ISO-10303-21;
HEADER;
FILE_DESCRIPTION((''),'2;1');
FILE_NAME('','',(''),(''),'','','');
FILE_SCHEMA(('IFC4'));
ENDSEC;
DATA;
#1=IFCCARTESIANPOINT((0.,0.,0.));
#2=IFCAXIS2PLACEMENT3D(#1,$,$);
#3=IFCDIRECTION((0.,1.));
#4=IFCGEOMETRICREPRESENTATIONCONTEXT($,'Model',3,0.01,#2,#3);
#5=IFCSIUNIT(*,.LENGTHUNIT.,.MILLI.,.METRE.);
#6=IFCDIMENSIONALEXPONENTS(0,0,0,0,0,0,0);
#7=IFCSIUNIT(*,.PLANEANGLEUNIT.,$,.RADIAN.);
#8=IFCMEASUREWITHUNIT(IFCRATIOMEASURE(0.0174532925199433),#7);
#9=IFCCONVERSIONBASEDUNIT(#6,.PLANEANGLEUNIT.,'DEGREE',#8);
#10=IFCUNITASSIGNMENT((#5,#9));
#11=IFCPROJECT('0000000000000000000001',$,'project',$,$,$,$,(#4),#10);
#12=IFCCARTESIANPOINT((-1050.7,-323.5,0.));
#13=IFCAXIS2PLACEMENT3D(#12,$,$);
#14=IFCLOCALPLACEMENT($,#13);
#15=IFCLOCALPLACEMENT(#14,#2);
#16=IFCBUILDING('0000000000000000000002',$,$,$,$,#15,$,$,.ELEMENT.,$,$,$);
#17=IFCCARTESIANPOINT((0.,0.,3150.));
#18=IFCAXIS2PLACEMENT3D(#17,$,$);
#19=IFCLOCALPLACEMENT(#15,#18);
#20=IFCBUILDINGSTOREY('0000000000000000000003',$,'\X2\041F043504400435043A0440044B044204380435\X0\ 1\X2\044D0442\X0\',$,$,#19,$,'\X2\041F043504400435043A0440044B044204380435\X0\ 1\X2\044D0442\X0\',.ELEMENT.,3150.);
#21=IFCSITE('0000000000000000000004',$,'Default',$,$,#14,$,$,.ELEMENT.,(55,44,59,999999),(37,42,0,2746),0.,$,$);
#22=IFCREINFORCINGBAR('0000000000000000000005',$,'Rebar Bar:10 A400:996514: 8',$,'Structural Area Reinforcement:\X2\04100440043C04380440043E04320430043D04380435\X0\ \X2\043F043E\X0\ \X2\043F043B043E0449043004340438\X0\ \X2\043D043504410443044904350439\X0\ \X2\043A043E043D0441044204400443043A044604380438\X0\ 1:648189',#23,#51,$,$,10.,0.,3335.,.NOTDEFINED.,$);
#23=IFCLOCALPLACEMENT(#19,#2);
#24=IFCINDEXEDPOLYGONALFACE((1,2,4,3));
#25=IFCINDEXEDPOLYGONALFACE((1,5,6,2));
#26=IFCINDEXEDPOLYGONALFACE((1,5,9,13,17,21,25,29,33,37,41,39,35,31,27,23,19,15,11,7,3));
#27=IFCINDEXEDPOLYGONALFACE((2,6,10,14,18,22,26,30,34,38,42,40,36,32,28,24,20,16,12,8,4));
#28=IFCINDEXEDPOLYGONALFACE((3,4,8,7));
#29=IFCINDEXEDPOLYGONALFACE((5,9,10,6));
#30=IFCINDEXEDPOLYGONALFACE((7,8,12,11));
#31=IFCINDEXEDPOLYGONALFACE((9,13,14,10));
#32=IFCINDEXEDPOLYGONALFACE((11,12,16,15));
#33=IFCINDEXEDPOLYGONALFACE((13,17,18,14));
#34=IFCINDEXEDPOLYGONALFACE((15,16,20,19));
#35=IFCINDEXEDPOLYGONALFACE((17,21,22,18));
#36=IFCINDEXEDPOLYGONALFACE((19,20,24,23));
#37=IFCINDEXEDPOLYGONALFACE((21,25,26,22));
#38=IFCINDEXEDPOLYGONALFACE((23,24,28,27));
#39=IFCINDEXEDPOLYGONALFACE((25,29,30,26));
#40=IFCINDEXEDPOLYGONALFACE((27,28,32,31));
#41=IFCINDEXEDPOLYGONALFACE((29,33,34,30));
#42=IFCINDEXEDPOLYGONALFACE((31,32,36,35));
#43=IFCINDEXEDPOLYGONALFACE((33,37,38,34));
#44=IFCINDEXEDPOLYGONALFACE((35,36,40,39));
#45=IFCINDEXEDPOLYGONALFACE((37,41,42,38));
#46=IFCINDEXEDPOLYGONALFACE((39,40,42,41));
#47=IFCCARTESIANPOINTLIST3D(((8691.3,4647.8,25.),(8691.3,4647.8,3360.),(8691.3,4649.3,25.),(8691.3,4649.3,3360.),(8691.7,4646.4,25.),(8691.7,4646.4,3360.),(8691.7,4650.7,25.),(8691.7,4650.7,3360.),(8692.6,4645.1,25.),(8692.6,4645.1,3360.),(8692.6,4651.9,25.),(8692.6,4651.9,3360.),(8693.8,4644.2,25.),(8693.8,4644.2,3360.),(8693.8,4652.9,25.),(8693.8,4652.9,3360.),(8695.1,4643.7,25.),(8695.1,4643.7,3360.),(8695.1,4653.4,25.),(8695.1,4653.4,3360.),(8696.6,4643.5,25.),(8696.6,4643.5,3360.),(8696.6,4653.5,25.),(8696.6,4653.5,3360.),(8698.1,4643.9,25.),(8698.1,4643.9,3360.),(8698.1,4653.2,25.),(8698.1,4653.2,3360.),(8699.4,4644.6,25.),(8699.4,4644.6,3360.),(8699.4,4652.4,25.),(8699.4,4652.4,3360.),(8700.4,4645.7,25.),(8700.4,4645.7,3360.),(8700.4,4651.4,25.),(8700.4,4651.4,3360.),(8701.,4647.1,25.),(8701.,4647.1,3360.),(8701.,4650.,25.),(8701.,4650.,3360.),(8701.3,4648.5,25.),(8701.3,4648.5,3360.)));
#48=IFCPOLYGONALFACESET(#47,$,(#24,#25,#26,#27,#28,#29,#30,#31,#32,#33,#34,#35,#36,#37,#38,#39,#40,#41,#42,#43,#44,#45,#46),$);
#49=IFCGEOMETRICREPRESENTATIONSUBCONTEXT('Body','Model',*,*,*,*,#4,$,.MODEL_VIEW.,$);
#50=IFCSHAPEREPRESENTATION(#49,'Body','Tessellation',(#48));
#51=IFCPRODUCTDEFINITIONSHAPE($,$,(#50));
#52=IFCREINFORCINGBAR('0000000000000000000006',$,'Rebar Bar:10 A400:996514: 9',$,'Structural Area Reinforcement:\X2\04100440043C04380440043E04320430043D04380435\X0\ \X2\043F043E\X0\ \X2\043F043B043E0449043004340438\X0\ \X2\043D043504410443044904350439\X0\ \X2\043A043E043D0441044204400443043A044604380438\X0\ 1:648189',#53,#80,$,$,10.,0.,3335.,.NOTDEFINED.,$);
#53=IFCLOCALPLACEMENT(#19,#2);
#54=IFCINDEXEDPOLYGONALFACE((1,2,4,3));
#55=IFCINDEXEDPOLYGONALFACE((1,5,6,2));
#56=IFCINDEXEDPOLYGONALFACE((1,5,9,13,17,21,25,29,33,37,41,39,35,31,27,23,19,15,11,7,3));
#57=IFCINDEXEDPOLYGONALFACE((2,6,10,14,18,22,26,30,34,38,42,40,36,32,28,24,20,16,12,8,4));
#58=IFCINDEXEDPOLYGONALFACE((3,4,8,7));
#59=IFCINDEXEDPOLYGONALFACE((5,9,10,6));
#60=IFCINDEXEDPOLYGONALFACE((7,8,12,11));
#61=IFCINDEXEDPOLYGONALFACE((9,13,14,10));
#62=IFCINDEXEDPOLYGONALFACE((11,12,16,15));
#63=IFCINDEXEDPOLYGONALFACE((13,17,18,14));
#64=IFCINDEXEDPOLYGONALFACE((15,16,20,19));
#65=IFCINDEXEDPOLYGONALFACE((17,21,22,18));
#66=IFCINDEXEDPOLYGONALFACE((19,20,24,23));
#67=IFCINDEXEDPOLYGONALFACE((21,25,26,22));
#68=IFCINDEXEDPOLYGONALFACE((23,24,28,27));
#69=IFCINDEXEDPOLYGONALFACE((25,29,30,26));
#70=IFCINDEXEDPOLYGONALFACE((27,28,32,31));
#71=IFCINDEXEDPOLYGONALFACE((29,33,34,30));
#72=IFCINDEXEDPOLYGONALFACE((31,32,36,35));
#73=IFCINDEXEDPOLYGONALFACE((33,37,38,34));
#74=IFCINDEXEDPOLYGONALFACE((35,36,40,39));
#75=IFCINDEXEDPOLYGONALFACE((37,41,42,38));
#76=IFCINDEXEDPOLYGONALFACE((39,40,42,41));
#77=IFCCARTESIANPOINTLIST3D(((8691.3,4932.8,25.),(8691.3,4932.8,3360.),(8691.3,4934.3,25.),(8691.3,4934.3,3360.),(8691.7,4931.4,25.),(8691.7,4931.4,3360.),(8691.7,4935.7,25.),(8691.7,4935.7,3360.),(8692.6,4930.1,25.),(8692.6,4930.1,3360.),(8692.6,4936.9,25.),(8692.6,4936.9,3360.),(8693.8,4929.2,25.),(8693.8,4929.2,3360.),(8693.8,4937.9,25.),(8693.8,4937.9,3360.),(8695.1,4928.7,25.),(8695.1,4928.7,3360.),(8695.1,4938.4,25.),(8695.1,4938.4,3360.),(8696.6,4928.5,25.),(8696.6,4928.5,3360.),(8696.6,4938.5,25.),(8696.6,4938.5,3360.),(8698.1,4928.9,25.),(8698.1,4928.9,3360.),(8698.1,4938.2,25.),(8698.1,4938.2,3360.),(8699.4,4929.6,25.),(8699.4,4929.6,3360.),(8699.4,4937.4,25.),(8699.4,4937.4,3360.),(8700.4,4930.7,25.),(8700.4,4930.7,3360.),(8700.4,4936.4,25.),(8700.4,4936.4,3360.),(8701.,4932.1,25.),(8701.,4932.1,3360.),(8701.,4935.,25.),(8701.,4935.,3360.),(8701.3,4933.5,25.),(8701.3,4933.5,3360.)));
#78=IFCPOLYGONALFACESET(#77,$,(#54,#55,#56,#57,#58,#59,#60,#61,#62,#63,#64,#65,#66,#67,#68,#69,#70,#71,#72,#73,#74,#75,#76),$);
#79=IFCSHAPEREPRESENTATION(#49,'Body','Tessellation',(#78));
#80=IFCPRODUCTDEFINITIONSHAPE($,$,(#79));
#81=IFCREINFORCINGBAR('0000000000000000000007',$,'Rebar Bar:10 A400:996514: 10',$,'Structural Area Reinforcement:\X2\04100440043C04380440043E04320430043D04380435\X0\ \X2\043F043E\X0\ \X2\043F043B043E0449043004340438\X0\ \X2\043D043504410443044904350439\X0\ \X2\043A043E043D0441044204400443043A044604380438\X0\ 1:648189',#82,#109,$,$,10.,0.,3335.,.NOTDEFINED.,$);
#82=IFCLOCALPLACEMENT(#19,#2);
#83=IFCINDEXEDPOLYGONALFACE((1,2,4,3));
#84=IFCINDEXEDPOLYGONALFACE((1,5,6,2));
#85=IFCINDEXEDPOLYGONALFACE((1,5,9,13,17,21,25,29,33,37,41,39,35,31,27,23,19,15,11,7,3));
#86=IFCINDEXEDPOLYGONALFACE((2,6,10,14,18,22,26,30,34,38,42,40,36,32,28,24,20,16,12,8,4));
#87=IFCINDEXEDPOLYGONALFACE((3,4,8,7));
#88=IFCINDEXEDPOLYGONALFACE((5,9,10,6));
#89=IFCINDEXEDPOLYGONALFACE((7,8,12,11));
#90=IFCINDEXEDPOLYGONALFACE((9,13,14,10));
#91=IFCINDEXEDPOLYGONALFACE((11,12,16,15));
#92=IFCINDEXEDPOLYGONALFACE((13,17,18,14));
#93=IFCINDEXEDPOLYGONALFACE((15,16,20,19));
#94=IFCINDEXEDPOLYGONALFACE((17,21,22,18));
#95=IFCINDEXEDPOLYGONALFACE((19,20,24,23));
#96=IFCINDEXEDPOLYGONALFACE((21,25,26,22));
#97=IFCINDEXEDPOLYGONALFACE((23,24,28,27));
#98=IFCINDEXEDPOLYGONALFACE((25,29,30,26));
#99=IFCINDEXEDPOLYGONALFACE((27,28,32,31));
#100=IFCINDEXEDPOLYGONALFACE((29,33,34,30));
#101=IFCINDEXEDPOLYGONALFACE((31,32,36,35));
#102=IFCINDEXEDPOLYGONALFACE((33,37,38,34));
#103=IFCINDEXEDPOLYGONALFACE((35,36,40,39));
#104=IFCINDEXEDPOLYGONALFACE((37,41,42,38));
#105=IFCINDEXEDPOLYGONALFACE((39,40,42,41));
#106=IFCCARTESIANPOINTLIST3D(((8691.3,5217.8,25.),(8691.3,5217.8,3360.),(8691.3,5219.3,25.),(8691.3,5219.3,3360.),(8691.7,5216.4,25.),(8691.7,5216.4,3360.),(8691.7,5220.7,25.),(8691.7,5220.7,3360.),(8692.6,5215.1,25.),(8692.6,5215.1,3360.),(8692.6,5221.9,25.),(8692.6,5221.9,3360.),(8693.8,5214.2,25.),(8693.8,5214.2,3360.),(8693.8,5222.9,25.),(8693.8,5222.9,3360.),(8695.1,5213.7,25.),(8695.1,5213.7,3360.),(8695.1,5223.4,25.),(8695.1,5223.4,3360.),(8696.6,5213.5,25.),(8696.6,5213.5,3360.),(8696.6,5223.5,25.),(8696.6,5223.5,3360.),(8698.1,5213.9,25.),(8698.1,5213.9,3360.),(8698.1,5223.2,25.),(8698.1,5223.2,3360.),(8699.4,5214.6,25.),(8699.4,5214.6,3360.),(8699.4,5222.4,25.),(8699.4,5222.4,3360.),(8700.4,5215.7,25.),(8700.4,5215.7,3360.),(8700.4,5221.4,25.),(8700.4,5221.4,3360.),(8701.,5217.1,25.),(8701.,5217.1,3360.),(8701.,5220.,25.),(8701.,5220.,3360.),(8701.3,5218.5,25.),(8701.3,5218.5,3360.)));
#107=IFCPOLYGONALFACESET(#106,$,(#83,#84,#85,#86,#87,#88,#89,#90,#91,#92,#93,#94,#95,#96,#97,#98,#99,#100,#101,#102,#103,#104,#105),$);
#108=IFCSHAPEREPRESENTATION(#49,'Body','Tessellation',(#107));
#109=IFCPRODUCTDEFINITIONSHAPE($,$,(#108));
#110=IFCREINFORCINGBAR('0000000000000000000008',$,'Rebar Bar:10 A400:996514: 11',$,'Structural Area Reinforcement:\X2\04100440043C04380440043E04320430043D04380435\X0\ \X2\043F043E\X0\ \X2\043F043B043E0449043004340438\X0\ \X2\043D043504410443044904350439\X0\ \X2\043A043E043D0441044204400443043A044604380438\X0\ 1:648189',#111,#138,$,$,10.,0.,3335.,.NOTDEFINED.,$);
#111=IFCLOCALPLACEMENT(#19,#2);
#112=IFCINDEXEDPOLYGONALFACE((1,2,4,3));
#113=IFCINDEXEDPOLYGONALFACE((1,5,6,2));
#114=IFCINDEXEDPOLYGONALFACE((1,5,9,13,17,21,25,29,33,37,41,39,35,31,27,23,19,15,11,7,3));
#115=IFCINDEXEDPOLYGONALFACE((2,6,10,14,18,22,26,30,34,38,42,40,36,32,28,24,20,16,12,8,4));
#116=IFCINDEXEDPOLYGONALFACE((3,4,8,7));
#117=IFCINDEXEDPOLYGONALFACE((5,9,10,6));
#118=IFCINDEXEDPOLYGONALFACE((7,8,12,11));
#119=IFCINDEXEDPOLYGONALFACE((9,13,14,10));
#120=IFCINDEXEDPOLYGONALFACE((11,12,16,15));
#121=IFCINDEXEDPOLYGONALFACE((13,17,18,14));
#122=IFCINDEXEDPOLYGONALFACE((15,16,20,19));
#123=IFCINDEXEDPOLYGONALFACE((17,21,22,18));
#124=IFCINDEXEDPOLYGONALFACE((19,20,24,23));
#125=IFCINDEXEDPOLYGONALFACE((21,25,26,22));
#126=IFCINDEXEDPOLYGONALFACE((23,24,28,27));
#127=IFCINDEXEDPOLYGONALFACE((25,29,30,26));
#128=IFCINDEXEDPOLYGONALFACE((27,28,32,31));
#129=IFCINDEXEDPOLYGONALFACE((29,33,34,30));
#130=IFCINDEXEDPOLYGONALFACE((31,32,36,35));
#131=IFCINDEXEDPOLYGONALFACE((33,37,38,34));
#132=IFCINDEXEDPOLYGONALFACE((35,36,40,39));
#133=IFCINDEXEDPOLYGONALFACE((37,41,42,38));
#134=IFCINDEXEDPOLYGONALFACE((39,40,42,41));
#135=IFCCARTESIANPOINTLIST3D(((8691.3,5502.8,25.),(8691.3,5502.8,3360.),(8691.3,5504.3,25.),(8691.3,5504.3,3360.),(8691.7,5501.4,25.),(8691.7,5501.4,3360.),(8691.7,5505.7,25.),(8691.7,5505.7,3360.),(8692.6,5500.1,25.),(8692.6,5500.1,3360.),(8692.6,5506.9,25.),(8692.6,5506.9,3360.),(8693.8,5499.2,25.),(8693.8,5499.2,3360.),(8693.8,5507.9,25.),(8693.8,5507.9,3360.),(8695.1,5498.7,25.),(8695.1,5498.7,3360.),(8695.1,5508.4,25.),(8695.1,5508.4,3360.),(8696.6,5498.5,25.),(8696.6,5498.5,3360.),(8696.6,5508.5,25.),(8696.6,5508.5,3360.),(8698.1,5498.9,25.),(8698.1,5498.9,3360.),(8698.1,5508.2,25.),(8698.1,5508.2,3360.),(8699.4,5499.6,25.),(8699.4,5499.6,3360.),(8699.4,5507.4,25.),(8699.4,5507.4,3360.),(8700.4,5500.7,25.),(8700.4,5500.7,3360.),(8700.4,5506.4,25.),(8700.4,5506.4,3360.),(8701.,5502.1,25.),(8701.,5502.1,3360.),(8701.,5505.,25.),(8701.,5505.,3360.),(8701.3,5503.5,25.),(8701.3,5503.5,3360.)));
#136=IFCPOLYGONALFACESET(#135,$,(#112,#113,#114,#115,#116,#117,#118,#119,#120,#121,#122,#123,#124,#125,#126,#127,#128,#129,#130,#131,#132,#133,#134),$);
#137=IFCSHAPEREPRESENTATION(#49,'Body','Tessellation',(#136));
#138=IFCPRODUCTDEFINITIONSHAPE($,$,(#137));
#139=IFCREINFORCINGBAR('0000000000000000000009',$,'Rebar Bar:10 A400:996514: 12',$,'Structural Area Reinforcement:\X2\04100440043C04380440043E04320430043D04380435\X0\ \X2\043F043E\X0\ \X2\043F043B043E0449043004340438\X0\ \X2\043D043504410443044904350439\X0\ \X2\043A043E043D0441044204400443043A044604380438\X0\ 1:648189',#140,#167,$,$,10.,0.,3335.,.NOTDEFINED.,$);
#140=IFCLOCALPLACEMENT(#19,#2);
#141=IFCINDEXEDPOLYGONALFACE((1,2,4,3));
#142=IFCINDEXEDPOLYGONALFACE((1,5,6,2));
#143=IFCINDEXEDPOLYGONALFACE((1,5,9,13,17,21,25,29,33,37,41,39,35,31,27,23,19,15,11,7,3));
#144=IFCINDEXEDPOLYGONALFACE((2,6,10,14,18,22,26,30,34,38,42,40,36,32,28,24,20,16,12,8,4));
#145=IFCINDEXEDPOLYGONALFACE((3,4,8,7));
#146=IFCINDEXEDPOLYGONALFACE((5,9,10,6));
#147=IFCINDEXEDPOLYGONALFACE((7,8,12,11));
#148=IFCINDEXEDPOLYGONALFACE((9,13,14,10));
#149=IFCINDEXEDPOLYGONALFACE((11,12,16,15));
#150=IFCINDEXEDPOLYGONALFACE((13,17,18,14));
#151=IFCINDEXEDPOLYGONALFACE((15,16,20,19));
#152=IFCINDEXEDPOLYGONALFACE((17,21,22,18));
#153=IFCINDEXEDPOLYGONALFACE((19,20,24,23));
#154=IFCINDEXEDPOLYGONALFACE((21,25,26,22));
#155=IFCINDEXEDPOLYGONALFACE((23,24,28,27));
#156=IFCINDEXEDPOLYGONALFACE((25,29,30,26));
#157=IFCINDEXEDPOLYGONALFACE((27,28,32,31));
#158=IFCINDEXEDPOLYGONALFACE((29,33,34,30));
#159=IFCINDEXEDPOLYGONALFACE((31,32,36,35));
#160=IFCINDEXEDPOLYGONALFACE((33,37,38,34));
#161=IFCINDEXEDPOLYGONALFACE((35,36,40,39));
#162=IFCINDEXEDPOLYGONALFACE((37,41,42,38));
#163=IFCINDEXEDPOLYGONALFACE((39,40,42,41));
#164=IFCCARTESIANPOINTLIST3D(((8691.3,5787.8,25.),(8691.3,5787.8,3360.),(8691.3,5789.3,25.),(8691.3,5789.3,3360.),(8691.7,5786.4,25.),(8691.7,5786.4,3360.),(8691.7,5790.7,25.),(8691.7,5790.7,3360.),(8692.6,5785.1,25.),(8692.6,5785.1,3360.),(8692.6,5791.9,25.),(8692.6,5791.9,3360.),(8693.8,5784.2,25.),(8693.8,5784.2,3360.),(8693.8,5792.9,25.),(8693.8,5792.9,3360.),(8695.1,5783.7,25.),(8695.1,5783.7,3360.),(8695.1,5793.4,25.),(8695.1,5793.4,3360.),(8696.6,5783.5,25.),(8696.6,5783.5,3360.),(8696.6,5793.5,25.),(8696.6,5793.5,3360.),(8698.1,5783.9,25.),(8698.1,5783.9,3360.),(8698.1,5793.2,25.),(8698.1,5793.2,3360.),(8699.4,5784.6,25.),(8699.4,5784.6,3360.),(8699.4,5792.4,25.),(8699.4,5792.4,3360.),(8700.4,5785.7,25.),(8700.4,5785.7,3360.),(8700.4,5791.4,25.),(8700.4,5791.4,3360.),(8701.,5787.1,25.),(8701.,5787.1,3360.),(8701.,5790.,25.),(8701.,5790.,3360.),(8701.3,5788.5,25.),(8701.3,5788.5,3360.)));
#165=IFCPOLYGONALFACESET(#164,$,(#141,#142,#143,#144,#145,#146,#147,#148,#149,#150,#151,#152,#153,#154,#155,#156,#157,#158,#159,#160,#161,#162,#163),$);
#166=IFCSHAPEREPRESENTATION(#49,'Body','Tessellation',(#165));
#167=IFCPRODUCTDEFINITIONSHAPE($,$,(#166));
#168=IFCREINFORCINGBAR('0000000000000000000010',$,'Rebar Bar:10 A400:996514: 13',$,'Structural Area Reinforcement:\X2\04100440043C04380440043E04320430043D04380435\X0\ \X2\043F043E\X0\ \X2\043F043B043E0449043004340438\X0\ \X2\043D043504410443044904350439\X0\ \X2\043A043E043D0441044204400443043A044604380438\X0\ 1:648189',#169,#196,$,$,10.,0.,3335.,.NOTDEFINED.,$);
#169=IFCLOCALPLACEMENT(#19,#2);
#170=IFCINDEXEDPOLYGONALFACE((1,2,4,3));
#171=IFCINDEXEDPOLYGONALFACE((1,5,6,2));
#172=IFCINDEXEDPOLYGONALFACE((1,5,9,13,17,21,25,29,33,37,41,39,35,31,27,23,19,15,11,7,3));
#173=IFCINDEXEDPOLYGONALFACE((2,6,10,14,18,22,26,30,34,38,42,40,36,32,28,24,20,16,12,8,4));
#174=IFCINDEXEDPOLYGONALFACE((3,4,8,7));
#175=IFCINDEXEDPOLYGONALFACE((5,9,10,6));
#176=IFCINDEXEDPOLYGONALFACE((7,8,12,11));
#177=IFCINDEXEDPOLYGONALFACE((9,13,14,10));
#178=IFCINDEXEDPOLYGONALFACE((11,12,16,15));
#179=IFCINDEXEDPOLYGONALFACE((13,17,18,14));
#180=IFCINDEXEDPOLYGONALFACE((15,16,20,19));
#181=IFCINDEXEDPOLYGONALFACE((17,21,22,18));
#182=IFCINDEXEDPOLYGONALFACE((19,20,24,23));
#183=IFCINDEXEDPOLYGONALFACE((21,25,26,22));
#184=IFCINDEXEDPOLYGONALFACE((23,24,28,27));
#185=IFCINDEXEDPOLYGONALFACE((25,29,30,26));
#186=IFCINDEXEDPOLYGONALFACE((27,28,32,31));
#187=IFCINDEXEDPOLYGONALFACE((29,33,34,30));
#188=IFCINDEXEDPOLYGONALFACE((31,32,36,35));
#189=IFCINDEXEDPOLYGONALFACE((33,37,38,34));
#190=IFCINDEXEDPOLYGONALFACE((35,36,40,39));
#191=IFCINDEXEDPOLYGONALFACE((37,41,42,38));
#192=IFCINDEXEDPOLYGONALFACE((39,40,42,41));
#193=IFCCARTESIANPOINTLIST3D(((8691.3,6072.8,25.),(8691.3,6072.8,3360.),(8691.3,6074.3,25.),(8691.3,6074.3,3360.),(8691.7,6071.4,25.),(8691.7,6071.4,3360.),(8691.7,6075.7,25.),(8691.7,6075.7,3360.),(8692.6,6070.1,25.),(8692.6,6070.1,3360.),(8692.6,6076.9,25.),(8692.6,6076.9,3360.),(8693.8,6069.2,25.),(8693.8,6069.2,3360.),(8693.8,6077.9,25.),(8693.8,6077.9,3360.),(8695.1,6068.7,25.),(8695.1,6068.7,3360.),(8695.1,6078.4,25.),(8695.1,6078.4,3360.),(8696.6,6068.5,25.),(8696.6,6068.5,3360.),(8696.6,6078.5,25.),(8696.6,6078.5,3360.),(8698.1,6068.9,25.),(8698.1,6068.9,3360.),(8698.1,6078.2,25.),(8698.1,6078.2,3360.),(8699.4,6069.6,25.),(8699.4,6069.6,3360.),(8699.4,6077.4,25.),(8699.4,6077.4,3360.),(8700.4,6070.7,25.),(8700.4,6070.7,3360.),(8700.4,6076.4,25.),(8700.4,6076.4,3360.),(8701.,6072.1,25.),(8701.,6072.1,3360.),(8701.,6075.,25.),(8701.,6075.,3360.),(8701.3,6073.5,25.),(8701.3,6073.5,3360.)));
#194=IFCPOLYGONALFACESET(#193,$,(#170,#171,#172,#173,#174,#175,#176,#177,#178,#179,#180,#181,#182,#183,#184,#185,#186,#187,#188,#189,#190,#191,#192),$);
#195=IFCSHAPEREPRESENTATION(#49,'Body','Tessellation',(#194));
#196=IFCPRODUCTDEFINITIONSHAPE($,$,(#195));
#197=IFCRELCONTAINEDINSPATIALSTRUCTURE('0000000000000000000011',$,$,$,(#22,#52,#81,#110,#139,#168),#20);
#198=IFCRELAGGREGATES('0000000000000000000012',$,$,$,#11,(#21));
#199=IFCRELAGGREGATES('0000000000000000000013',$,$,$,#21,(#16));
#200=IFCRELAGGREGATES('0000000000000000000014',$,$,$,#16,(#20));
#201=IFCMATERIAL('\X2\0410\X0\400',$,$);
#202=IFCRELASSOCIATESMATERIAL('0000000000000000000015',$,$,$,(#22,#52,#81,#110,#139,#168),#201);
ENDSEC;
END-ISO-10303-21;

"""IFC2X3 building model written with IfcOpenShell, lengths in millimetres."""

from ifc_helpers import new_model, entity, si_unit, converted_unit, direction, frame, origin, place, context, subcontext, project, spatial, material, element, save


model = new_model("IFC2X3")

# Units and contexts
model_context = context("Model", 3, precision=0.01, world=origin(), true_north=direction((0.0, 1.0)))
body_context = subcontext(model_context, "Body", "Model", "MODEL_VIEW")
ifc_project = project(units=[si_unit("LENGTHUNIT", "METRE", prefix="MILLI"), converted_unit("PLANEANGLEUNIT", "DEGREE", entity("IfcRatioMeasure", 0.0174532925199433), si_unit("PLANEANGLEUNIT", "RADIAN"), dimensions=[0, 0, 0, 0, 0, 0, 0])], contexts=[model_context])

# Site, building, storey
site_placement = place(None, frame((-1050.7, -323.5, 0.0)))
site = spatial("IfcSite", under=ifc_project, at=site_placement, Name="Default", CompositionType="ELEMENT", RefLatitude=(55, 44, 59, 999999), RefLongitude=(37, 42, 0, 2746), RefElevation=0.0)
building_placement = place(site_placement, origin())
building = spatial("IfcBuilding", under=site, at=building_placement, CompositionType="ELEMENT")
storey_placement = place(building_placement, frame((0.0, 0.0, 3150.0)))
storey = spatial("IfcBuildingStorey", under=building, at=storey_placement, Name="Перекрытие 1эт", LongName="Перекрытие 1эт", CompositionType="ELEMENT", Elevation=3150.0)

# Reinforcing bars
ifc_material = material(Name="А400")
reinforcing_bar_1_placement = place(storey_placement, origin())
element("IfcReinforcingBar", 1, at=reinforcing_bar_1_placement, inside=storey, material=ifc_material, Name="Rebar Bar:10 A400:996514: 8", ObjectType="Structural Area Reinforcement:Армирование по площади несущей конструкции 1:648189", BarLength=3335.0, BarRole="NOTDEFINED", CrossSectionArea=0.0, NominalDiameter=10.0, context=body_context, shape_type="AdvancedSweptSolid", body=[
    entity("IfcSweptDiskSolid", entity("IfcCompositeCurve", [entity("IfcCompositeCurveSegment", "CONTINUOUS", True, entity("IfcPolyline", [entity("IfcCartesianPoint", [8696.3, 4648.5, 25.0]), entity("IfcCartesianPoint", [8696.3, 4648.5, 3360.0])]))], False), 5.0, None, 0.0, 1.0),
])
reinforcing_bar_2_placement = place(storey_placement, origin())
element("IfcReinforcingBar", 2, at=reinforcing_bar_2_placement, inside=storey, material=ifc_material, Name="Rebar Bar:10 A400:996514: 9", ObjectType="Structural Area Reinforcement:Армирование по площади несущей конструкции 1:648189", BarLength=3335.0, BarRole="NOTDEFINED", CrossSectionArea=0.0, NominalDiameter=10.0, context=body_context, shape_type="AdvancedSweptSolid", body=[
    entity("IfcSweptDiskSolid", entity("IfcCompositeCurve", [entity("IfcCompositeCurveSegment", "CONTINUOUS", True, entity("IfcPolyline", [entity("IfcCartesianPoint", [8696.3, 4933.5, 25.0]), entity("IfcCartesianPoint", [8696.3, 4933.5, 3360.0])]))], False), 5.0, None, 0.0, 1.0),
])
reinforcing_bar_3_placement = place(storey_placement, origin())
element("IfcReinforcingBar", 3, at=reinforcing_bar_3_placement, inside=storey, material=ifc_material, Name="Rebar Bar:10 A400:996514: 10", ObjectType="Structural Area Reinforcement:Армирование по площади несущей конструкции 1:648189", BarLength=3335.0, BarRole="NOTDEFINED", CrossSectionArea=0.0, NominalDiameter=10.0, context=body_context, shape_type="AdvancedSweptSolid", body=[
    entity("IfcSweptDiskSolid", entity("IfcCompositeCurve", [entity("IfcCompositeCurveSegment", "CONTINUOUS", True, entity("IfcPolyline", [entity("IfcCartesianPoint", [8696.3, 5218.5, 25.0]), entity("IfcCartesianPoint", [8696.3, 5218.5, 3360.0])]))], False), 5.0, None, 0.0, 1.0),
])
reinforcing_bar_4_placement = place(storey_placement, origin())
element("IfcReinforcingBar", 4, at=reinforcing_bar_4_placement, inside=storey, material=ifc_material, Name="Rebar Bar:10 A400:996514: 11", ObjectType="Structural Area Reinforcement:Армирование по площади несущей конструкции 1:648189", BarLength=3335.0, BarRole="NOTDEFINED", CrossSectionArea=0.0, NominalDiameter=10.0, context=body_context, shape_type="AdvancedSweptSolid", body=[
    entity("IfcSweptDiskSolid", entity("IfcCompositeCurve", [entity("IfcCompositeCurveSegment", "CONTINUOUS", True, entity("IfcPolyline", [entity("IfcCartesianPoint", [8696.3, 5503.5, 25.0]), entity("IfcCartesianPoint", [8696.3, 5503.5, 3360.0])]))], False), 5.0, None, 0.0, 1.0),
])
reinforcing_bar_5_placement = place(storey_placement, origin())
element("IfcReinforcingBar", 5, at=reinforcing_bar_5_placement, inside=storey, material=ifc_material, Name="Rebar Bar:10 A400:996514: 12", ObjectType="Structural Area Reinforcement:Армирование по площади несущей конструкции 1:648189", BarLength=3335.0, BarRole="NOTDEFINED", CrossSectionArea=0.0, NominalDiameter=10.0, context=body_context, shape_type="AdvancedSweptSolid", body=[
    entity("IfcSweptDiskSolid", entity("IfcCompositeCurve", [entity("IfcCompositeCurveSegment", "CONTINUOUS", True, entity("IfcPolyline", [entity("IfcCartesianPoint", [8696.3, 5788.5, 25.0]), entity("IfcCartesianPoint", [8696.3, 5788.5, 3360.0])]))], False), 5.0, None, 0.0, 1.0),
])
reinforcing_bar_6_placement = place(storey_placement, origin())
element("IfcReinforcingBar", 6, at=reinforcing_bar_6_placement, inside=storey, material=ifc_material, Name="Rebar Bar:10 A400:996514: 13", ObjectType="Structural Area Reinforcement:Армирование по площади несущей конструкции 1:648189", BarLength=3335.0, BarRole="NOTDEFINED", CrossSectionArea=0.0, NominalDiameter=10.0, context=body_context, shape_type="AdvancedSweptSolid", body=[
    entity("IfcSweptDiskSolid", entity("IfcCompositeCurve", [entity("IfcCompositeCurveSegment", "CONTINUOUS", True, entity("IfcPolyline", [entity("IfcCartesianPoint", [8696.3, 6073.5, 25.0]), entity("IfcCartesianPoint", [8696.3, 6073.5, 3360.0])]))], False), 5.0, None, 0.0, 1.0),
])

save(model, "model.ifc")
